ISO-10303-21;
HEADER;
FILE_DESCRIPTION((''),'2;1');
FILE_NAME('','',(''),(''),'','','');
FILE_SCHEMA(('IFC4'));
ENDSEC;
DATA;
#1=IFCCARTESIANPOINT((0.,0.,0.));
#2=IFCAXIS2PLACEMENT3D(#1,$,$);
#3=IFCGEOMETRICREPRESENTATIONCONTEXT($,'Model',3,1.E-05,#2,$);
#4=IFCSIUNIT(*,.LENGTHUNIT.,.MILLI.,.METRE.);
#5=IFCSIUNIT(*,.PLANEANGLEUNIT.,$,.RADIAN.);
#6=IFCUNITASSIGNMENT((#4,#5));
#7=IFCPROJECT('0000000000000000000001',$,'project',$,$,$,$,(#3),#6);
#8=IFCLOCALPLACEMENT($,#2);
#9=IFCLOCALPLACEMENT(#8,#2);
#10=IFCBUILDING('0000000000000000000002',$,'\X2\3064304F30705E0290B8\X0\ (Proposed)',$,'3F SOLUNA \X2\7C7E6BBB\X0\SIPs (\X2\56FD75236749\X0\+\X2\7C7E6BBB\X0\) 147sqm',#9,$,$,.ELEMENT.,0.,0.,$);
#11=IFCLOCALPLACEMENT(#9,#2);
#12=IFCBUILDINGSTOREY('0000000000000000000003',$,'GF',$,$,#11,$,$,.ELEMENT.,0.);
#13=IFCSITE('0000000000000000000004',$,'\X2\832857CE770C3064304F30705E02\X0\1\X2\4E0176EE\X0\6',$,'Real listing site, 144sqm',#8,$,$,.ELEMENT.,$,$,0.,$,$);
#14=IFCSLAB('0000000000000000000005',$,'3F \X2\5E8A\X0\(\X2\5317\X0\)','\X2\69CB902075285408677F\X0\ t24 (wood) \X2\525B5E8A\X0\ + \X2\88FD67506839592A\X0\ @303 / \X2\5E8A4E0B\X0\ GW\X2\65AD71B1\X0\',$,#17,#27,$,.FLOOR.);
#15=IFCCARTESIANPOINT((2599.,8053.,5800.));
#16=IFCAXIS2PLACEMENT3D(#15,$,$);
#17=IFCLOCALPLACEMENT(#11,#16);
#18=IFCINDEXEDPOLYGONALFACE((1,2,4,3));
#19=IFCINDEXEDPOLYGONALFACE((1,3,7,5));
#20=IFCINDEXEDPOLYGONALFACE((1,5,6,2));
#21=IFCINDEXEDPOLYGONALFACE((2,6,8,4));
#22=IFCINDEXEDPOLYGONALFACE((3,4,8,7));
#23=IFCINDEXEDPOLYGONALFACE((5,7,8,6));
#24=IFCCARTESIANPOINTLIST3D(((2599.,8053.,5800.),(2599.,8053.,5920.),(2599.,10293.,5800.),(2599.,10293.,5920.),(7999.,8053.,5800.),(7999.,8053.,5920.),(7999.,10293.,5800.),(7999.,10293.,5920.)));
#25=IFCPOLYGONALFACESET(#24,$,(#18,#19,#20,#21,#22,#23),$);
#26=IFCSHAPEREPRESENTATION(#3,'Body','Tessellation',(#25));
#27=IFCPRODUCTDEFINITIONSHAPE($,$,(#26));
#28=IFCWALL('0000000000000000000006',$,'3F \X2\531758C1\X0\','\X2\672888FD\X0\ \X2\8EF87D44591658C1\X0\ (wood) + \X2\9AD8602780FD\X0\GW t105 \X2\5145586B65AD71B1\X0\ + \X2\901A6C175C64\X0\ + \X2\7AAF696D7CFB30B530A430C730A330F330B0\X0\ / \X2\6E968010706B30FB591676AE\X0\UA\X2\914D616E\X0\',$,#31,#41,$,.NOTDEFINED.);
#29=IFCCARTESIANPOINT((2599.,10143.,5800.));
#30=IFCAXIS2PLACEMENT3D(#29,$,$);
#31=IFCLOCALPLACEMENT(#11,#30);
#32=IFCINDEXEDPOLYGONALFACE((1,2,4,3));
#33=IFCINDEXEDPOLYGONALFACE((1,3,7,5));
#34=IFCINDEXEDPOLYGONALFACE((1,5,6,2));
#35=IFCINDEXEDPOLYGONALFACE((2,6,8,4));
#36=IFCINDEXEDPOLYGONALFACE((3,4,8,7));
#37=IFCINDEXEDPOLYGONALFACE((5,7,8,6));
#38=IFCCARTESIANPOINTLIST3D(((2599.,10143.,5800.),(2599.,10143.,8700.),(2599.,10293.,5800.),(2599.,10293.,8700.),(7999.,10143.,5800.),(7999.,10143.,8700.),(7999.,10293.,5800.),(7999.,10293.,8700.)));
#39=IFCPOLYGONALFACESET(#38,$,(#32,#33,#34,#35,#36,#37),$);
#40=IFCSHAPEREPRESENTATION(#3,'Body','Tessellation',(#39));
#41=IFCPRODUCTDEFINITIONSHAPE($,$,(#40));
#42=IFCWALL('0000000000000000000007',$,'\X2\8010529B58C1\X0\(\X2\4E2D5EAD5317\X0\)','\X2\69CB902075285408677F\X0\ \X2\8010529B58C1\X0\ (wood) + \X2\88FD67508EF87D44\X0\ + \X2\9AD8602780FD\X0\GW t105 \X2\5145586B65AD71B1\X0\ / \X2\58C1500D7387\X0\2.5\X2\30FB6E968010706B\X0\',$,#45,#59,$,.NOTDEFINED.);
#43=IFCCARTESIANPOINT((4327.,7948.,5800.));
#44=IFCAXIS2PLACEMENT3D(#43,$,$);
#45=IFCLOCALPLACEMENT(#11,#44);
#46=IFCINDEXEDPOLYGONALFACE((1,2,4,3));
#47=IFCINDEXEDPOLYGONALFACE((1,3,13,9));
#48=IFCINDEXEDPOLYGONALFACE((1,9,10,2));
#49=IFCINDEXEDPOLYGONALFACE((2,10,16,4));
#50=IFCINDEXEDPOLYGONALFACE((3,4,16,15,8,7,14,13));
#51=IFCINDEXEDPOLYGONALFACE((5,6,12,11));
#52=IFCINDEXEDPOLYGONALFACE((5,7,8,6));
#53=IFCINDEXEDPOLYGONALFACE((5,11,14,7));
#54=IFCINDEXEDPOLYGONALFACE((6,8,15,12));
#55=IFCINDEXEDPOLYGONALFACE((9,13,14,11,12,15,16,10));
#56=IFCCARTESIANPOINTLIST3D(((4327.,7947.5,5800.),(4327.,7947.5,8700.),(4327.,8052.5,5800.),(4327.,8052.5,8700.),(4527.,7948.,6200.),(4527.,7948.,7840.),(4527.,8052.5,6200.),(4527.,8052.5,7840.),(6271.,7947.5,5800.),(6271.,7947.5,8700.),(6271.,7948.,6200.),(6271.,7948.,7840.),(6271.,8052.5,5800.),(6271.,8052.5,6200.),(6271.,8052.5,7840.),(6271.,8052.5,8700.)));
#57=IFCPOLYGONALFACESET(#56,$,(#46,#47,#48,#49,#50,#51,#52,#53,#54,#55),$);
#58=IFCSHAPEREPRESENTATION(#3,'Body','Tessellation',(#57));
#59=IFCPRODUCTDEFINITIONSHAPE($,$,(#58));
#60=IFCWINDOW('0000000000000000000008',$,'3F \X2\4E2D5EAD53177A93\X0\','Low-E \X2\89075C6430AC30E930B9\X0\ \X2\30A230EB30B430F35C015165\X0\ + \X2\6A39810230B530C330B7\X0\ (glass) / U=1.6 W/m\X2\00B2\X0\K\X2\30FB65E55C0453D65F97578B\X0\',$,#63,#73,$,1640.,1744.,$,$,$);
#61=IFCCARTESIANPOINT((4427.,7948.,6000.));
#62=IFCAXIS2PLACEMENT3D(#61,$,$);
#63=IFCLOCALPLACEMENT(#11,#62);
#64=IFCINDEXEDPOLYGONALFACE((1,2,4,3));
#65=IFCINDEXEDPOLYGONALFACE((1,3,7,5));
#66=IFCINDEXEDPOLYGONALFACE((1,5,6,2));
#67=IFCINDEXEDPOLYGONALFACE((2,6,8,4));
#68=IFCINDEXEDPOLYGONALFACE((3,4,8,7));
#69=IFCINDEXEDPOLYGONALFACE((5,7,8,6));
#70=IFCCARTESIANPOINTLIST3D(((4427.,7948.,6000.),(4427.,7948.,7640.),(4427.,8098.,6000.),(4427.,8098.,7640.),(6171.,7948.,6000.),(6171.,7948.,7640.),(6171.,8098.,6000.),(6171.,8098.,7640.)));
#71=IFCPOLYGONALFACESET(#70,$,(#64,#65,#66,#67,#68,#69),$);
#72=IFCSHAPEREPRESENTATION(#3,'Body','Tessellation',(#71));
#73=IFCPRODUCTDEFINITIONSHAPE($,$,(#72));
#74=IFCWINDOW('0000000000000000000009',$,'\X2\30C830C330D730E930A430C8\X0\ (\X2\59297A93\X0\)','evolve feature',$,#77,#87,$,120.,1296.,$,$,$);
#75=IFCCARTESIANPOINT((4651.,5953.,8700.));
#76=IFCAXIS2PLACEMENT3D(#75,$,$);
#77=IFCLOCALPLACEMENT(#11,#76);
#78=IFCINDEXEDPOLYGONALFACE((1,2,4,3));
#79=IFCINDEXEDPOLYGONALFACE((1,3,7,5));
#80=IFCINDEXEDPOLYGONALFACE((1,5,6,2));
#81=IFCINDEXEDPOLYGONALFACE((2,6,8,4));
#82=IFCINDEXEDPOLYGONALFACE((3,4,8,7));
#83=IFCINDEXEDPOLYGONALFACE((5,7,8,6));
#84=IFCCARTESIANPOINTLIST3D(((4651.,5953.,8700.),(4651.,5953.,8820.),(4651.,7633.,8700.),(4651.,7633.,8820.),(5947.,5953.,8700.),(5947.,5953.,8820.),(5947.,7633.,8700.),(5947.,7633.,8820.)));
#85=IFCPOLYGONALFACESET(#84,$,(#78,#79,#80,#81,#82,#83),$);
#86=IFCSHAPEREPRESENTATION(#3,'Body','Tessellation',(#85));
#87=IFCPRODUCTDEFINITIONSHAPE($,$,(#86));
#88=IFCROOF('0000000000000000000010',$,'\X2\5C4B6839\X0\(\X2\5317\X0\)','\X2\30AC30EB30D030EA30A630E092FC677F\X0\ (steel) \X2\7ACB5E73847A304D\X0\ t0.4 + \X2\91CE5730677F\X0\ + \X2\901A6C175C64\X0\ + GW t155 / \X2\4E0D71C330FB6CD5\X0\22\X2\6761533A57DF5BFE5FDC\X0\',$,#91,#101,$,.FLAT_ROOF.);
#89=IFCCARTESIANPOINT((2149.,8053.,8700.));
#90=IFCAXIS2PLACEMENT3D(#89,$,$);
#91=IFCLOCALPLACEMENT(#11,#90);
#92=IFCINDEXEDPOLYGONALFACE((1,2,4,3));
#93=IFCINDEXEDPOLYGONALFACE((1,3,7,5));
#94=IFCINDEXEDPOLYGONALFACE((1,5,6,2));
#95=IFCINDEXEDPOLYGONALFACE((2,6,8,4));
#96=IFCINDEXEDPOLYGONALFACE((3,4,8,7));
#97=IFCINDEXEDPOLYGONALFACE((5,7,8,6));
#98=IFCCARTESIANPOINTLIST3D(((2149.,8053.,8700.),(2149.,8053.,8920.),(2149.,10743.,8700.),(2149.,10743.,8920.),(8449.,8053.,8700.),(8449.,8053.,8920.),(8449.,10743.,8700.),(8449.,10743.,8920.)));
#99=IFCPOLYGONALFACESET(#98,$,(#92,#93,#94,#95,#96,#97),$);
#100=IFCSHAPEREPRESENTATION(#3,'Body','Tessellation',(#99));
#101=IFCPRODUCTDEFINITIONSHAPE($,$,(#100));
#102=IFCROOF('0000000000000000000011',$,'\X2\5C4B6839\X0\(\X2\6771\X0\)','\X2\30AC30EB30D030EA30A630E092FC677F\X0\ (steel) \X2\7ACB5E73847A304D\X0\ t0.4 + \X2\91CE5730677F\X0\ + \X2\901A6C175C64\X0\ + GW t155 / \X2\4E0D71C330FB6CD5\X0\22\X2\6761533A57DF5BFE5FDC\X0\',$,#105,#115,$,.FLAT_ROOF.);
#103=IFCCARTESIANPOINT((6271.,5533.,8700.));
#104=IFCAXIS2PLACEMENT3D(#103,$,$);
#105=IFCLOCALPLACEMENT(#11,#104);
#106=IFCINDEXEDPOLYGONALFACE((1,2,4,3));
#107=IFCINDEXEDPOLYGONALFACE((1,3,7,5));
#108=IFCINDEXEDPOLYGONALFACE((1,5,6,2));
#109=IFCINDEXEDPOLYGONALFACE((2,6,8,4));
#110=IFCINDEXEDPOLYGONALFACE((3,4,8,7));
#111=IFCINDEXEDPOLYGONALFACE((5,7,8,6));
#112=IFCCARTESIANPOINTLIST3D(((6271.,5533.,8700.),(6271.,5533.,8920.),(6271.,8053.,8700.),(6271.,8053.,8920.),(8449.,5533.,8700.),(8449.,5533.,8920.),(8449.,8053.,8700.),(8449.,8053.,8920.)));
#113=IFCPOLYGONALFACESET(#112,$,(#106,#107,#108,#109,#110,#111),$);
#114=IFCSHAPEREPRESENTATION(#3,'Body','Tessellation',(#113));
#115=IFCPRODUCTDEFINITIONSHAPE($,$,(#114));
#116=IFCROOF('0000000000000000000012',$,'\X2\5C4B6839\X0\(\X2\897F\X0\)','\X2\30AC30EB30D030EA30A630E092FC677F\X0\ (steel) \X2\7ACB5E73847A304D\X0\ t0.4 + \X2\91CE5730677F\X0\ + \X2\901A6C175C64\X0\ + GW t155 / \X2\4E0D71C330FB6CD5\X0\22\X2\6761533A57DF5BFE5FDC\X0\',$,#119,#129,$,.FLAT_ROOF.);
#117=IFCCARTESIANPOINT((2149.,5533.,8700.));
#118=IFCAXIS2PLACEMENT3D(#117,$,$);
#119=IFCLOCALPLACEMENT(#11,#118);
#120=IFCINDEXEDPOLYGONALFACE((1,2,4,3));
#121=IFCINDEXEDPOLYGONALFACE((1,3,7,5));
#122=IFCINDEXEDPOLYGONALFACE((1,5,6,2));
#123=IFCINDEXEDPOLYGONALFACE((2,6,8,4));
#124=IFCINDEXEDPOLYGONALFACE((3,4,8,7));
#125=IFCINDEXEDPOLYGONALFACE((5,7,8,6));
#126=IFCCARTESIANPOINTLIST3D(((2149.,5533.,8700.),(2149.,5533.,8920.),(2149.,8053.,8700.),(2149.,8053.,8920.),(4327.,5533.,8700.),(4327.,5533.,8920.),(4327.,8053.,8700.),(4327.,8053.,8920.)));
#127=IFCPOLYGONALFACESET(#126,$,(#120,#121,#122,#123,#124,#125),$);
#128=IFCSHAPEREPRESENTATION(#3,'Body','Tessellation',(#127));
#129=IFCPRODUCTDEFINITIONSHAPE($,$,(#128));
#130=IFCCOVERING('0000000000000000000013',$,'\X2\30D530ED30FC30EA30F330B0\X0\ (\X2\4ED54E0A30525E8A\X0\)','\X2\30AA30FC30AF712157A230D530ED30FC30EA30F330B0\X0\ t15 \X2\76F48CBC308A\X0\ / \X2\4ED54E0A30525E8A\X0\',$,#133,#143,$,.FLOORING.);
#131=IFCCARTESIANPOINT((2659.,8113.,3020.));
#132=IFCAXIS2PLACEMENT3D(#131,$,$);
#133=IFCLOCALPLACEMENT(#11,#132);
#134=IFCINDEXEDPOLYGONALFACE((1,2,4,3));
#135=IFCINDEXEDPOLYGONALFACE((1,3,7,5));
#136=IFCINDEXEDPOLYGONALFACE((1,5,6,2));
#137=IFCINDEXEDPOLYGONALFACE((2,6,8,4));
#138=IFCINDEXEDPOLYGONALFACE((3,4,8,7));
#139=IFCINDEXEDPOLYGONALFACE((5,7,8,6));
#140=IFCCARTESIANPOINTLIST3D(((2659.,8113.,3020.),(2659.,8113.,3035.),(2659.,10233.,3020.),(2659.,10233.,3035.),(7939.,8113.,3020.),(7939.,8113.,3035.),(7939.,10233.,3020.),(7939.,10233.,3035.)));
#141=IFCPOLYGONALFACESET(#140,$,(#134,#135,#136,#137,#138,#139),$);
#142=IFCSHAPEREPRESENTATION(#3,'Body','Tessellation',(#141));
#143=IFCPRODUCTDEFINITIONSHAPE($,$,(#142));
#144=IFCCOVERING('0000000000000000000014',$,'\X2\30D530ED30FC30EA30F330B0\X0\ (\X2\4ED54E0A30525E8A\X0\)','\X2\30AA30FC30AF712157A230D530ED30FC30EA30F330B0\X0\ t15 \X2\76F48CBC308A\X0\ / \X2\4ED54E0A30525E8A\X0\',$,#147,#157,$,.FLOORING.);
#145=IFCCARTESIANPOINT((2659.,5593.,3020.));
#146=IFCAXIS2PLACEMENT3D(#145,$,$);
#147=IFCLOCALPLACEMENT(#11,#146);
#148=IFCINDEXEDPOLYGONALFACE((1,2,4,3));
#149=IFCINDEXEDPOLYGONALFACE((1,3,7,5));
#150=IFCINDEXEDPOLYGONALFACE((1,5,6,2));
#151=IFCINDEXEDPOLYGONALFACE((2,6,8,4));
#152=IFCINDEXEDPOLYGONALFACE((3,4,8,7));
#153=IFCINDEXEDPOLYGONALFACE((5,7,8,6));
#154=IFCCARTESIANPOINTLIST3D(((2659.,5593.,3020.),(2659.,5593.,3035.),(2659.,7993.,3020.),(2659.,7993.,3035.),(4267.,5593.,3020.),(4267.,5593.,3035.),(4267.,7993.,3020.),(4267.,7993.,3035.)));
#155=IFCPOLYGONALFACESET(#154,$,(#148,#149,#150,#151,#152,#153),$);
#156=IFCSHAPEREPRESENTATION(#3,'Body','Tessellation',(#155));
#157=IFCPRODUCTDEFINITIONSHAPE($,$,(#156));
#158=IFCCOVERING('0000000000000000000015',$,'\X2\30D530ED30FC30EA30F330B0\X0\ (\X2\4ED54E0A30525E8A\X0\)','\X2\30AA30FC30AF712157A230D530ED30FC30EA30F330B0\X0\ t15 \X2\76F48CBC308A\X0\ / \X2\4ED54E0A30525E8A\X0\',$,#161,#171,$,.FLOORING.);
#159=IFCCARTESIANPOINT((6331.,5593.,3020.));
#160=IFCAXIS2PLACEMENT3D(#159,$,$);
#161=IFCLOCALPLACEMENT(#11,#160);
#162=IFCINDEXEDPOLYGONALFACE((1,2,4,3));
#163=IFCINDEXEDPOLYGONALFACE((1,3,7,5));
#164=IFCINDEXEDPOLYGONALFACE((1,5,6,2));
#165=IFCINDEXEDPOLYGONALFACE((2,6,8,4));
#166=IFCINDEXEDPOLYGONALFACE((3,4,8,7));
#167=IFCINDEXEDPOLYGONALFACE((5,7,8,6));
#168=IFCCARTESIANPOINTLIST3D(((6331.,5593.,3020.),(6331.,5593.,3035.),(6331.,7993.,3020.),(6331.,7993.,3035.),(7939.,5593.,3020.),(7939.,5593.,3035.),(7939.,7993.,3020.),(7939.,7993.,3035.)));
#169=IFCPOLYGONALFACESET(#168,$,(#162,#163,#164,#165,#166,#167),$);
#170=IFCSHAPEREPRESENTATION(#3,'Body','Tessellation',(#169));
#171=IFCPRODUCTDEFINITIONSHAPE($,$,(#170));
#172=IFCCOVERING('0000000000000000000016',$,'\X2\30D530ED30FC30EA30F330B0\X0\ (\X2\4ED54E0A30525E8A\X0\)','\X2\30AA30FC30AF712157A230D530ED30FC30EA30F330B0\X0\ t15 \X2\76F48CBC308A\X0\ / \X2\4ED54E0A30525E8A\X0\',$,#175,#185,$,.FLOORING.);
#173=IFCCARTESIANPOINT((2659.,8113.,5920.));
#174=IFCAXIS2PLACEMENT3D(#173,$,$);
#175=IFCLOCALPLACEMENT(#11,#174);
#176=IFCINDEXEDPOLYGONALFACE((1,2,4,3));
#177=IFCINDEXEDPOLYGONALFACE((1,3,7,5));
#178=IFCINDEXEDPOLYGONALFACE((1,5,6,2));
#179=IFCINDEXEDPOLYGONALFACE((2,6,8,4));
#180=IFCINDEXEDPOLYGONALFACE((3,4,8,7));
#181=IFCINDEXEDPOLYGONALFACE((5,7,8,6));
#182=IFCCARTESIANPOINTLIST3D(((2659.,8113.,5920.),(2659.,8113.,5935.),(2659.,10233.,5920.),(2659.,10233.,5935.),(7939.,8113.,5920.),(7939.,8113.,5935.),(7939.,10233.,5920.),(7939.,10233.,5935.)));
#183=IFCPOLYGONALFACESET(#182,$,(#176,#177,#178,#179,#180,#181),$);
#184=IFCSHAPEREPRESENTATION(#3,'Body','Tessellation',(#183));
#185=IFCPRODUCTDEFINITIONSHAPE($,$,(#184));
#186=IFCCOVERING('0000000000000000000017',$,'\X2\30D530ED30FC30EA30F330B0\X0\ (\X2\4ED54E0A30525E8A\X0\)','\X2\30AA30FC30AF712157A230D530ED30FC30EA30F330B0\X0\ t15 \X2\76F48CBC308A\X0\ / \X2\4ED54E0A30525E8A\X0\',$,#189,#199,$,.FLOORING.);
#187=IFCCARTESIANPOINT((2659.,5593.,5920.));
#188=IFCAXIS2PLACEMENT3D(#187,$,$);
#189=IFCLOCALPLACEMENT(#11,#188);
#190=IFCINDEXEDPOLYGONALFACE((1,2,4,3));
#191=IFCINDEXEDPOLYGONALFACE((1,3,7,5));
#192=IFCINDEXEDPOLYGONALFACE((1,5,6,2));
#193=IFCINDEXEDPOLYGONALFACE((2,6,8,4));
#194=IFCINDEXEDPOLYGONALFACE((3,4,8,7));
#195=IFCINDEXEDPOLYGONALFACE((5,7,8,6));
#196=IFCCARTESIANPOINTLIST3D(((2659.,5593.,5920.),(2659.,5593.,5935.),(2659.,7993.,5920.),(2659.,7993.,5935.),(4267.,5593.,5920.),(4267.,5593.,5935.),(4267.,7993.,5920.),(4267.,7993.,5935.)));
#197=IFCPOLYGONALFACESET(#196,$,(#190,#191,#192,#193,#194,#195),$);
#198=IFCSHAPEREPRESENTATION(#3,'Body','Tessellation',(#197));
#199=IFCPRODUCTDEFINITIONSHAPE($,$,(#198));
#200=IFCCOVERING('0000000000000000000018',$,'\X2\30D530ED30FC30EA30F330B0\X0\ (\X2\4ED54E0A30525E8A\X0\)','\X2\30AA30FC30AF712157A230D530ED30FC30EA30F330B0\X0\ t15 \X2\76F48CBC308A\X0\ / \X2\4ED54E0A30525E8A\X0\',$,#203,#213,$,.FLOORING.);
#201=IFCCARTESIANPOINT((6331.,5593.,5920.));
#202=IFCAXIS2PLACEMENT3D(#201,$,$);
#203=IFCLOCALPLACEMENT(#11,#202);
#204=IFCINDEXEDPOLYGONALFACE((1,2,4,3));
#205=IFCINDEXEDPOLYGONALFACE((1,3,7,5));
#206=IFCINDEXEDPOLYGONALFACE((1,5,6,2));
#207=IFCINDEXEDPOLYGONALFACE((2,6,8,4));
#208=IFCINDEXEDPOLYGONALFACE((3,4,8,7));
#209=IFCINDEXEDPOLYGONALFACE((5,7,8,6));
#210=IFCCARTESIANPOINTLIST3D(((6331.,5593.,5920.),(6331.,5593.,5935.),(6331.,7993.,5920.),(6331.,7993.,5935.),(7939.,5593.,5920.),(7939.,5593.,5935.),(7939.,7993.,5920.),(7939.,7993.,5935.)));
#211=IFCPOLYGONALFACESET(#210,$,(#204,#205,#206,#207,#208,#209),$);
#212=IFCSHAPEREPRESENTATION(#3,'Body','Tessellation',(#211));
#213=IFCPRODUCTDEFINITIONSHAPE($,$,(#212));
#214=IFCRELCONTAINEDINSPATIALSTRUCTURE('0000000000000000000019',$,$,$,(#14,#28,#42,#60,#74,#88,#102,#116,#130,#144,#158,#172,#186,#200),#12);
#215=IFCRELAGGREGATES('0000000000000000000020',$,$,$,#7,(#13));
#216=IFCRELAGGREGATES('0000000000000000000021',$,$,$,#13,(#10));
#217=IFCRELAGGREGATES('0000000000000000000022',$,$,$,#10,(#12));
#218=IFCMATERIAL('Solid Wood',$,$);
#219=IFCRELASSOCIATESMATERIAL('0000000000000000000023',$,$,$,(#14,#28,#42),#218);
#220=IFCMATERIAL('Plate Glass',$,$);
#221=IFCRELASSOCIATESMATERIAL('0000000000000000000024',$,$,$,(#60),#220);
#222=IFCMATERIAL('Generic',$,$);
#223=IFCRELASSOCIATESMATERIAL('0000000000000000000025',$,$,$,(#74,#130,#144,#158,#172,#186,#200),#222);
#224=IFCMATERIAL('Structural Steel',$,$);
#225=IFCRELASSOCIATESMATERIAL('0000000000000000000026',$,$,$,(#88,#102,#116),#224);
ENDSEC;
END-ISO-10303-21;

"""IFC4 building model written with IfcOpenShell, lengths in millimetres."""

from ifc_helpers import new_model, si_unit, frame, frame_2d, origin, place, context, project, spatial, rectangle, extrude, material, element, fill, save


model = new_model("IFC4")

# Units and contexts
model_context = context("Model", 3, precision=1e-05, world=origin())
ifc_project = project(units=[si_unit("LENGTHUNIT", "METRE", prefix="MILLI"), si_unit("PLANEANGLEUNIT", "RADIAN")], contexts=[model_context])

# Site, building, storey
site_placement = place(None, origin())
site = spatial("IfcSite", under=ifc_project, at=site_placement, Name="茨城県つくば市1丁目6", ObjectType="Real listing site, 144sqm", CompositionType="ELEMENT", RefElevation=0.0)
building_placement = place(site_placement, origin())
building = spatial("IfcBuilding", under=site, at=building_placement, Name="つくば市邸 (Proposed)", ObjectType="3F SOLUNA 籾殻SIPs (国産杉+籾殻) 147sqm", CompositionType="ELEMENT", ElevationOfRefHeight=0.0, ElevationOfTerrain=0.0)
storey_placement = place(building_placement, origin())
storey = spatial("IfcBuildingStorey", under=building, at=storey_placement, Name="GF", CompositionType="ELEMENT", Elevation=0.0)

# Slab
ifc_material_1 = material(Name="Solid Wood")
slab_placement = place(storey_placement, frame((2599.0, 8053.0, 5800.0)))
element("IfcSlab", 1, at=slab_placement, inside=storey, material=ifc_material_1, Name="3F 床(北)", Description="構造用合板 t24 (wood) 剛床 + 製材根太 @303 / 床下 GW断熱", PredefinedType="FLOOR", context=model_context, shape_type="SweptSolid", body=[
    extrude(rectangle(XDim=5400.0, YDim=2240.0, at=frame_2d((2700.0, 1120.0))), frame((2599.0, 8053.0, 5800.0)), (0.0, 0.0, 1.0), 120.0),
])

# Wall
wall_1_placement = place(storey_placement, frame((2599.0, 10143.0, 5800.0)))
element("IfcWall", 2, at=wall_1_placement, inside=storey, material=ifc_material_1, Name="3F 北壁", Description="木製 軸組外壁 (wood) + 高性能GW t105 充填断熱 + 通気層 + 窯業系サイディング / 準耐火・外皮UA配慮", PredefinedType="NOTDEFINED", context=model_context, shape_type="SweptSolid", body=[
    extrude(rectangle(XDim=5400.0, YDim=150.0, at=frame_2d((2700.0, 75.0))), frame((2599.0, 10143.0, 5800.0)), (0.0, 0.0, 1.0), 2900.0),
])

# Wall, opening, window
wall_2_placement = place(storey_placement, frame((4327.0, 7948.0, 5800.0)))
wall_2 = element("IfcWall", 3, at=wall_2_placement, inside=storey, material=ifc_material_1, Name="耐力壁(中庭北)", Description="構造用合板 耐力壁 (wood) + 製材軸組 + 高性能GW t105 充填断熱 / 壁倍率2.5・準耐火", PredefinedType="NOTDEFINED", context=model_context, shape_type="SweptSolid", body=[
    extrude(rectangle(XDim=1944.0, YDim=105.0, at=frame_2d((972.0, 52.0))), frame((4327.0, 7948.0, 5800.0)), (0.0, 0.0, 1.0), 2900.0),
])
opening_placement = place(storey_placement, frame((4427.0, 7948.0, 6000.0)))
opening = element("IfcOpeningElement", 4, at=opening_placement, cuts=wall_2, PredefinedType="NOTDEFINED", context=model_context, shape_type="SweptSolid", body=[
    extrude(rectangle(XDim=1744.0, YDim=150.0, at=frame_2d((872.0, 75.0))), frame((4427.0, 7948.0, 6000.0)), (0.0, 0.0, 1.0), 1640.0),
])
ifc_material_2 = material(Name="Plate Glass")
window_1_placement = place(storey_placement, frame((4427.0, 7948.0, 6000.0)))
window_1 = element("IfcWindow", 5, at=window_1_placement, inside=storey, material=ifc_material_2, Name="3F 中庭北窓", Description="Low-E 複層ガラス アルゴン封入 + 樹脂サッシ (glass) / U=1.6 W/m²K・日射取得型", OverallHeight=1640.0, OverallWidth=1744.0, context=model_context, shape_type="SweptSolid", body=[
    extrude(rectangle(XDim=1744.0, YDim=150.0, at=frame_2d((872.0, 75.0))), frame((4427.0, 7948.0, 6000.0)), (0.0, 0.0, 1.0), 1640.0),
])
fill(opening, window_1)

# Window
ifc_material_3 = material(Name="Generic")
window_2_placement = place(storey_placement, frame((4651.0, 5953.0, 8700.0)))
element("IfcWindow", 6, at=window_2_placement, inside=storey, material=ifc_material_3, Name="トップライト (天窓)", Description="evolve feature", OverallHeight=120.0, OverallWidth=1296.0, context=model_context, shape_type="SweptSolid", body=[
    extrude(rectangle(XDim=1296.0, YDim=1680.0, at=frame_2d((648.0, 840.0))), frame((4651.0, 5953.0, 8700.0)), (0.0, 0.0, 1.0), 120.0),
])

# Roofs
ifc_material_4 = material(Name="Structural Steel")
roof_1_placement = place(storey_placement, frame((2149.0, 8053.0, 8700.0)))
element("IfcRoof", 7, at=roof_1_placement, inside=storey, material=ifc_material_4, Name="屋根(北)", Description="ガルバリウム鋼板 (steel) 立平葺き t0.4 + 野地板 + 通気層 + GW t155 / 不燃・法22条区域対応", PredefinedType="FLAT_ROOF", context=model_context, shape_type="SweptSolid", body=[
    extrude(rectangle(XDim=6300.0, YDim=2690.0, at=frame_2d((3150.0, 1345.0))), frame((2149.0, 8053.0, 8700.0)), (0.0, 0.0, 1.0), 220.0),
])
roof_2_placement = place(storey_placement, frame((6271.0, 5533.0, 8700.0)))
element("IfcRoof", 8, at=roof_2_placement, inside=storey, material=ifc_material_4, Name="屋根(東)", Description="ガルバリウム鋼板 (steel) 立平葺き t0.4 + 野地板 + 通気層 + GW t155 / 不燃・法22条区域対応", PredefinedType="FLAT_ROOF", context=model_context, shape_type="SweptSolid", body=[
    extrude(rectangle(XDim=2178.0, YDim=2520.0, at=frame_2d((1089.0, 1260.0))), frame((6271.0, 5533.0, 8700.0)), (0.0, 0.0, 1.0), 220.0),
])
roof_3_placement = place(storey_placement, frame((2149.0, 5533.0, 8700.0)))
element("IfcRoof", 9, at=roof_3_placement, inside=storey, material=ifc_material_4, Name="屋根(西)", Description="ガルバリウム鋼板 (steel) 立平葺き t0.4 + 野地板 + 通気層 + GW t155 / 不燃・法22条区域対応", PredefinedType="FLAT_ROOF", context=model_context, shape_type="SweptSolid", body=[
    extrude(rectangle(XDim=2178.0, YDim=2520.0, at=frame_2d((1089.0, 1260.0))), frame((2149.0, 5533.0, 8700.0)), (0.0, 0.0, 1.0), 220.0),
])

# Coverings
covering_1_placement = place(storey_placement, frame((2659.0, 8113.0, 3020.0)))
element("IfcCovering", 10, at=covering_1_placement, inside=storey, material=ifc_material_3, Name="フローリング (仕上げ床)", Description="オーク無垢フローリング t15 直貼り / 仕上げ床", PredefinedType="FLOORING", context=model_context, shape_type="SweptSolid", body=[
    extrude(rectangle(XDim=5280.0, YDim=2120.0, at=frame_2d((2640.0, 1060.0))), frame((2659.0, 8113.0, 3020.0)), (0.0, 0.0, 1.0), 15.0),
])
covering_2_placement = place(storey_placement, frame((2659.0, 5593.0, 3020.0)))
element("IfcCovering", 11, at=covering_2_placement, inside=storey, material=ifc_material_3, Name="フローリング (仕上げ床)", Description="オーク無垢フローリング t15 直貼り / 仕上げ床", PredefinedType="FLOORING", context=model_context, shape_type="SweptSolid", body=[
    extrude(rectangle(XDim=1608.0, YDim=2400.0, at=frame_2d((804.0, 1200.0))), frame((2659.0, 5593.0, 3020.0)), (0.0, 0.0, 1.0), 15.0),
])
covering_3_placement = place(storey_placement, frame((6331.0, 5593.0, 3020.0)))
element("IfcCovering", 12, at=covering_3_placement, inside=storey, material=ifc_material_3, Name="フローリング (仕上げ床)", Description="オーク無垢フローリング t15 直貼り / 仕上げ床", PredefinedType="FLOORING", context=model_context, shape_type="SweptSolid", body=[
    extrude(rectangle(XDim=1608.0, YDim=2400.0, at=frame_2d((804.0, 1200.0))), frame((6331.0, 5593.0, 3020.0)), (0.0, 0.0, 1.0), 15.0),
])
covering_4_placement = place(storey_placement, frame((2659.0, 8113.0, 5920.0)))
element("IfcCovering", 13, at=covering_4_placement, inside=storey, material=ifc_material_3, Name="フローリング (仕上げ床)", Description="オーク無垢フローリング t15 直貼り / 仕上げ床", PredefinedType="FLOORING", context=model_context, shape_type="SweptSolid", body=[
    extrude(rectangle(XDim=5280.0, YDim=2120.0, at=frame_2d((2640.0, 1060.0))), frame((2659.0, 8113.0, 5920.0)), (0.0, 0.0, 1.0), 15.0),
])
covering_5_placement = place(storey_placement, frame((2659.0, 5593.0, 5920.0)))
element("IfcCovering", 14, at=covering_5_placement, inside=storey, material=ifc_material_3, Name="フローリング (仕上げ床)", Description="オーク無垢フローリング t15 直貼り / 仕上げ床", PredefinedType="FLOORING", context=model_context, shape_type="SweptSolid", body=[
    extrude(rectangle(XDim=1608.0, YDim=2400.0, at=frame_2d((804.0, 1200.0))), frame((2659.0, 5593.0, 5920.0)), (0.0, 0.0, 1.0), 15.0),
])
covering_6_placement = place(storey_placement, frame((6331.0, 5593.0, 5920.0)))
element("IfcCovering", 15, at=covering_6_placement, inside=storey, material=ifc_material_3, Name="フローリング (仕上げ床)", Description="オーク無垢フローリング t15 直貼り / 仕上げ床", PredefinedType="FLOORING", context=model_context, shape_type="SweptSolid", body=[
    extrude(rectangle(XDim=1608.0, YDim=2400.0, at=frame_2d((804.0, 1200.0))), frame((6331.0, 5593.0, 5920.0)), (0.0, 0.0, 1.0), 15.0),
])

save(model, "model.ifc")
